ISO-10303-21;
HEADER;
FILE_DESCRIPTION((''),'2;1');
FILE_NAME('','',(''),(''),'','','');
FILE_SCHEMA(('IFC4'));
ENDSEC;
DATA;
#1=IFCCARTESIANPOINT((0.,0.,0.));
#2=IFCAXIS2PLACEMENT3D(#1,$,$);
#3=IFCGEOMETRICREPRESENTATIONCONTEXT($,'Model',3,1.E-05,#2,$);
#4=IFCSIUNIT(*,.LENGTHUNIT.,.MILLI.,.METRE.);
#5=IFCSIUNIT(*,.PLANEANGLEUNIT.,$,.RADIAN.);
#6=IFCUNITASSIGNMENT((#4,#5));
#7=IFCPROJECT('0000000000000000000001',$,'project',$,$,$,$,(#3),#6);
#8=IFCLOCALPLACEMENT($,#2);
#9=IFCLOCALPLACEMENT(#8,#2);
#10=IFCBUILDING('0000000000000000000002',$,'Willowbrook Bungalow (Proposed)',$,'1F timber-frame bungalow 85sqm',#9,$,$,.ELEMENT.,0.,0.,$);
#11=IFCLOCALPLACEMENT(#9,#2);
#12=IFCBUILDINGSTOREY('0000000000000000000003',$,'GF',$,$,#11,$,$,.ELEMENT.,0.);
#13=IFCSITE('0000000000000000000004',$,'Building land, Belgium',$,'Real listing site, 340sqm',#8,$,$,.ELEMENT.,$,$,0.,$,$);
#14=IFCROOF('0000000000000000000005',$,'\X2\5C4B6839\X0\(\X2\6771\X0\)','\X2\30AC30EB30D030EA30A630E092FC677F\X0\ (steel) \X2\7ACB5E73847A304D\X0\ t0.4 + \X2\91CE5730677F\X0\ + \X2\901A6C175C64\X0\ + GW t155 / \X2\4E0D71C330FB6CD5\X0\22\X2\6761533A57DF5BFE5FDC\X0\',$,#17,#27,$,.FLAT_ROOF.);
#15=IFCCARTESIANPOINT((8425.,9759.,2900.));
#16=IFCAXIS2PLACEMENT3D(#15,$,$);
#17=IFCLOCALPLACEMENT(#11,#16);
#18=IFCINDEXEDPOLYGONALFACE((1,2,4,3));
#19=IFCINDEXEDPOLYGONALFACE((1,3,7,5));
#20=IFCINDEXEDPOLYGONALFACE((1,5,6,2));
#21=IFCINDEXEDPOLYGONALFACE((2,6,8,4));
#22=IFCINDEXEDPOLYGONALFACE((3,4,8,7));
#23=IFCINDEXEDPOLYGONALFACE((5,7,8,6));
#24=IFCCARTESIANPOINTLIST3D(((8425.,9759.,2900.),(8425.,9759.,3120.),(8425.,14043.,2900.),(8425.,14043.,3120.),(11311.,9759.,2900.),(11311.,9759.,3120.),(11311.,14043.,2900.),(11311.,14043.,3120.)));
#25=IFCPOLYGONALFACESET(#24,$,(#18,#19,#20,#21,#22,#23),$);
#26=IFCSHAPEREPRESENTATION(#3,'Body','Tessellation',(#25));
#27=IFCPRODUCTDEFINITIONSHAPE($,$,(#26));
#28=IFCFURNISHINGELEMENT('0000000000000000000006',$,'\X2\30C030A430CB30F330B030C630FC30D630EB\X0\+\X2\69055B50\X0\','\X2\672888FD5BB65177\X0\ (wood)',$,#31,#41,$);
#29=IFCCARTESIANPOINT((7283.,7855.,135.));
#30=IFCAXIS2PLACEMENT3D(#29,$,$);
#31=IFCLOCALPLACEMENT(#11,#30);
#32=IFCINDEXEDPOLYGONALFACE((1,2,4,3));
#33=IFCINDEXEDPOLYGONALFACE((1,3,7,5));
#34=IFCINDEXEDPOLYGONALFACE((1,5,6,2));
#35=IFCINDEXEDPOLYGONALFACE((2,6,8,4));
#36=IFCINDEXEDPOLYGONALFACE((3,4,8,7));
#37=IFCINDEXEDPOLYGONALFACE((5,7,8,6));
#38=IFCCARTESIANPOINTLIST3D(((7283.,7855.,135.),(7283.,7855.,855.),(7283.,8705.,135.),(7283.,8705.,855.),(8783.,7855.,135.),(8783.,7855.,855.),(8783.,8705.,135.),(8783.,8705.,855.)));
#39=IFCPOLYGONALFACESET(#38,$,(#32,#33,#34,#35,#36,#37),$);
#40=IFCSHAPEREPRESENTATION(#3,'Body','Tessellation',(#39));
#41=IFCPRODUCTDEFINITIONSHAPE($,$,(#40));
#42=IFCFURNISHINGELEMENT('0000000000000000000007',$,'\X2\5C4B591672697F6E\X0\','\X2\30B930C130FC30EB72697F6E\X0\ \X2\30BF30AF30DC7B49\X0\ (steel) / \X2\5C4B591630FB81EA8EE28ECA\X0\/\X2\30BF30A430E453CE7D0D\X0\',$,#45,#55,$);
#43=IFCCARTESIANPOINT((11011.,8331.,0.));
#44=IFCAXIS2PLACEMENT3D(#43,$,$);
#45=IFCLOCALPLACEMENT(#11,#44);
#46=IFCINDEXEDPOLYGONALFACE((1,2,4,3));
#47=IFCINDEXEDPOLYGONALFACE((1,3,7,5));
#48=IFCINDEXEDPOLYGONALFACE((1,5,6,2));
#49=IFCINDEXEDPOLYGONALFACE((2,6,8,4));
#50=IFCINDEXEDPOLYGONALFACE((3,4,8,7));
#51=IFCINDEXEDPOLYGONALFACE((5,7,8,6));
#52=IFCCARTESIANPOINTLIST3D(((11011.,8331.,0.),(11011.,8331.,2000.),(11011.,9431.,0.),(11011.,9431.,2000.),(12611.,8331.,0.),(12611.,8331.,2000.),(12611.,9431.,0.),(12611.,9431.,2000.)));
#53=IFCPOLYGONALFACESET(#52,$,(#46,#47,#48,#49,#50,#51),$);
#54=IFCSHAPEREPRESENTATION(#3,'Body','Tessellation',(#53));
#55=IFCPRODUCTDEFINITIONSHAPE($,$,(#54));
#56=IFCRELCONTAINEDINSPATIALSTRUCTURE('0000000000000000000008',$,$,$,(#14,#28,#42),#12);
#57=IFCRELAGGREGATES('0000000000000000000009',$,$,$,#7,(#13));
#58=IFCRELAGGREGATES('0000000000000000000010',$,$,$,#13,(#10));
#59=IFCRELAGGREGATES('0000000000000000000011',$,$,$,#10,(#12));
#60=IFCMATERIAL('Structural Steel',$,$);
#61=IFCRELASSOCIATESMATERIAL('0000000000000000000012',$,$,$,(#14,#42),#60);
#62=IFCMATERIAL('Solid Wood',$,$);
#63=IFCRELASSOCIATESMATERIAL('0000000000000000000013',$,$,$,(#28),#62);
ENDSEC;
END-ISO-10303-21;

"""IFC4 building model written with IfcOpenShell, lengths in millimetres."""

from ifc_helpers import new_model, si_unit, frame, frame_2d, origin, place, context, project, spatial, rectangle, extrude, material, element, save


model = new_model("IFC4")

# Units and contexts
model_context = context("Model", 3, precision=1e-05, world=origin())
ifc_project = project(units=[si_unit("LENGTHUNIT", "METRE", prefix="MILLI"), si_unit("PLANEANGLEUNIT", "RADIAN")], contexts=[model_context])

# Site, building, storey
site_placement = place(None, origin())
site = spatial("IfcSite", under=ifc_project, at=site_placement, Name="Building land, Belgium", ObjectType="Real listing site, 340sqm", CompositionType="ELEMENT", RefElevation=0.0)
building_placement = place(site_placement, origin())
building = spatial("IfcBuilding", under=site, at=building_placement, Name="Willowbrook Bungalow (Proposed)", ObjectType="1F timber-frame bungalow 85sqm", CompositionType="ELEMENT", ElevationOfRefHeight=0.0, ElevationOfTerrain=0.0)
storey_placement = place(building_placement, origin())
storey = spatial("IfcBuildingStorey", under=building, at=storey_placement, Name="GF", CompositionType="ELEMENT", Elevation=0.0)

# Shared definitions
ifc_material_1 = material(Name="Solid Wood")

# Roof
ifc_material_2 = material(Name="Structural Steel")
roof_1_placement = place(storey_placement, frame((8425.0, 9759.0, 2900.0)))
element("IfcRoof", 1, at=roof_1_placement, inside=storey, material=ifc_material_2, Name="屋根(東)", Description="ガルバリウム鋼板 (steel) 立平葺き t0.4 + 野地板 + 通気層 + GW t155 / 不燃・法22条区域対応", PredefinedType="FLAT_ROOF", context=model_context, shape_type="SweptSolid", body=[
    extrude(rectangle(XDim=2886.0, YDim=4284.0, at=frame_2d((1443.0, 2142.0))), frame((8425.0, 9759.0, 2900.0)), (0.0, 0.0, 1.0), 220.0),
])

# Furnishing elements
furnishing_1_placement = place(storey_placement, frame((7283.0, 7855.0, 135.0)))
element("IfcFurnishingElement", 2, at=furnishing_1_placement, inside=storey, material=ifc_material_1, Name="ダイニングテーブル+椅子", Description="木製家具 (wood)", context=model_context, shape_type="SweptSolid", body=[
    extrude(rectangle(XDim=1500.0, YDim=850.0, at=frame_2d((750.0, 425.0))), frame((7283.0, 7855.0, 135.0)), (0.0, 0.0, 1.0), 720.0),
])
furnishing_2_placement = place(storey_placement, frame((11011.0, 8331.0, 0.0)))
element("IfcFurnishingElement", 3, at=furnishing_2_placement, inside=storey, material=ifc_material_2, Name="屋外物置", Description="スチール物置 タクボ等 (steel) / 屋外・自転車/タイヤ収納", context=model_context, shape_type="SweptSolid", body=[
    extrude(rectangle(XDim=1600.0, YDim=1100.0, at=frame_2d((800.0, 550.0))), frame((11011.0, 8331.0, 0.0)), (0.0, 0.0, 1.0), 2000.0),
])

save(model, "model.ifc")
